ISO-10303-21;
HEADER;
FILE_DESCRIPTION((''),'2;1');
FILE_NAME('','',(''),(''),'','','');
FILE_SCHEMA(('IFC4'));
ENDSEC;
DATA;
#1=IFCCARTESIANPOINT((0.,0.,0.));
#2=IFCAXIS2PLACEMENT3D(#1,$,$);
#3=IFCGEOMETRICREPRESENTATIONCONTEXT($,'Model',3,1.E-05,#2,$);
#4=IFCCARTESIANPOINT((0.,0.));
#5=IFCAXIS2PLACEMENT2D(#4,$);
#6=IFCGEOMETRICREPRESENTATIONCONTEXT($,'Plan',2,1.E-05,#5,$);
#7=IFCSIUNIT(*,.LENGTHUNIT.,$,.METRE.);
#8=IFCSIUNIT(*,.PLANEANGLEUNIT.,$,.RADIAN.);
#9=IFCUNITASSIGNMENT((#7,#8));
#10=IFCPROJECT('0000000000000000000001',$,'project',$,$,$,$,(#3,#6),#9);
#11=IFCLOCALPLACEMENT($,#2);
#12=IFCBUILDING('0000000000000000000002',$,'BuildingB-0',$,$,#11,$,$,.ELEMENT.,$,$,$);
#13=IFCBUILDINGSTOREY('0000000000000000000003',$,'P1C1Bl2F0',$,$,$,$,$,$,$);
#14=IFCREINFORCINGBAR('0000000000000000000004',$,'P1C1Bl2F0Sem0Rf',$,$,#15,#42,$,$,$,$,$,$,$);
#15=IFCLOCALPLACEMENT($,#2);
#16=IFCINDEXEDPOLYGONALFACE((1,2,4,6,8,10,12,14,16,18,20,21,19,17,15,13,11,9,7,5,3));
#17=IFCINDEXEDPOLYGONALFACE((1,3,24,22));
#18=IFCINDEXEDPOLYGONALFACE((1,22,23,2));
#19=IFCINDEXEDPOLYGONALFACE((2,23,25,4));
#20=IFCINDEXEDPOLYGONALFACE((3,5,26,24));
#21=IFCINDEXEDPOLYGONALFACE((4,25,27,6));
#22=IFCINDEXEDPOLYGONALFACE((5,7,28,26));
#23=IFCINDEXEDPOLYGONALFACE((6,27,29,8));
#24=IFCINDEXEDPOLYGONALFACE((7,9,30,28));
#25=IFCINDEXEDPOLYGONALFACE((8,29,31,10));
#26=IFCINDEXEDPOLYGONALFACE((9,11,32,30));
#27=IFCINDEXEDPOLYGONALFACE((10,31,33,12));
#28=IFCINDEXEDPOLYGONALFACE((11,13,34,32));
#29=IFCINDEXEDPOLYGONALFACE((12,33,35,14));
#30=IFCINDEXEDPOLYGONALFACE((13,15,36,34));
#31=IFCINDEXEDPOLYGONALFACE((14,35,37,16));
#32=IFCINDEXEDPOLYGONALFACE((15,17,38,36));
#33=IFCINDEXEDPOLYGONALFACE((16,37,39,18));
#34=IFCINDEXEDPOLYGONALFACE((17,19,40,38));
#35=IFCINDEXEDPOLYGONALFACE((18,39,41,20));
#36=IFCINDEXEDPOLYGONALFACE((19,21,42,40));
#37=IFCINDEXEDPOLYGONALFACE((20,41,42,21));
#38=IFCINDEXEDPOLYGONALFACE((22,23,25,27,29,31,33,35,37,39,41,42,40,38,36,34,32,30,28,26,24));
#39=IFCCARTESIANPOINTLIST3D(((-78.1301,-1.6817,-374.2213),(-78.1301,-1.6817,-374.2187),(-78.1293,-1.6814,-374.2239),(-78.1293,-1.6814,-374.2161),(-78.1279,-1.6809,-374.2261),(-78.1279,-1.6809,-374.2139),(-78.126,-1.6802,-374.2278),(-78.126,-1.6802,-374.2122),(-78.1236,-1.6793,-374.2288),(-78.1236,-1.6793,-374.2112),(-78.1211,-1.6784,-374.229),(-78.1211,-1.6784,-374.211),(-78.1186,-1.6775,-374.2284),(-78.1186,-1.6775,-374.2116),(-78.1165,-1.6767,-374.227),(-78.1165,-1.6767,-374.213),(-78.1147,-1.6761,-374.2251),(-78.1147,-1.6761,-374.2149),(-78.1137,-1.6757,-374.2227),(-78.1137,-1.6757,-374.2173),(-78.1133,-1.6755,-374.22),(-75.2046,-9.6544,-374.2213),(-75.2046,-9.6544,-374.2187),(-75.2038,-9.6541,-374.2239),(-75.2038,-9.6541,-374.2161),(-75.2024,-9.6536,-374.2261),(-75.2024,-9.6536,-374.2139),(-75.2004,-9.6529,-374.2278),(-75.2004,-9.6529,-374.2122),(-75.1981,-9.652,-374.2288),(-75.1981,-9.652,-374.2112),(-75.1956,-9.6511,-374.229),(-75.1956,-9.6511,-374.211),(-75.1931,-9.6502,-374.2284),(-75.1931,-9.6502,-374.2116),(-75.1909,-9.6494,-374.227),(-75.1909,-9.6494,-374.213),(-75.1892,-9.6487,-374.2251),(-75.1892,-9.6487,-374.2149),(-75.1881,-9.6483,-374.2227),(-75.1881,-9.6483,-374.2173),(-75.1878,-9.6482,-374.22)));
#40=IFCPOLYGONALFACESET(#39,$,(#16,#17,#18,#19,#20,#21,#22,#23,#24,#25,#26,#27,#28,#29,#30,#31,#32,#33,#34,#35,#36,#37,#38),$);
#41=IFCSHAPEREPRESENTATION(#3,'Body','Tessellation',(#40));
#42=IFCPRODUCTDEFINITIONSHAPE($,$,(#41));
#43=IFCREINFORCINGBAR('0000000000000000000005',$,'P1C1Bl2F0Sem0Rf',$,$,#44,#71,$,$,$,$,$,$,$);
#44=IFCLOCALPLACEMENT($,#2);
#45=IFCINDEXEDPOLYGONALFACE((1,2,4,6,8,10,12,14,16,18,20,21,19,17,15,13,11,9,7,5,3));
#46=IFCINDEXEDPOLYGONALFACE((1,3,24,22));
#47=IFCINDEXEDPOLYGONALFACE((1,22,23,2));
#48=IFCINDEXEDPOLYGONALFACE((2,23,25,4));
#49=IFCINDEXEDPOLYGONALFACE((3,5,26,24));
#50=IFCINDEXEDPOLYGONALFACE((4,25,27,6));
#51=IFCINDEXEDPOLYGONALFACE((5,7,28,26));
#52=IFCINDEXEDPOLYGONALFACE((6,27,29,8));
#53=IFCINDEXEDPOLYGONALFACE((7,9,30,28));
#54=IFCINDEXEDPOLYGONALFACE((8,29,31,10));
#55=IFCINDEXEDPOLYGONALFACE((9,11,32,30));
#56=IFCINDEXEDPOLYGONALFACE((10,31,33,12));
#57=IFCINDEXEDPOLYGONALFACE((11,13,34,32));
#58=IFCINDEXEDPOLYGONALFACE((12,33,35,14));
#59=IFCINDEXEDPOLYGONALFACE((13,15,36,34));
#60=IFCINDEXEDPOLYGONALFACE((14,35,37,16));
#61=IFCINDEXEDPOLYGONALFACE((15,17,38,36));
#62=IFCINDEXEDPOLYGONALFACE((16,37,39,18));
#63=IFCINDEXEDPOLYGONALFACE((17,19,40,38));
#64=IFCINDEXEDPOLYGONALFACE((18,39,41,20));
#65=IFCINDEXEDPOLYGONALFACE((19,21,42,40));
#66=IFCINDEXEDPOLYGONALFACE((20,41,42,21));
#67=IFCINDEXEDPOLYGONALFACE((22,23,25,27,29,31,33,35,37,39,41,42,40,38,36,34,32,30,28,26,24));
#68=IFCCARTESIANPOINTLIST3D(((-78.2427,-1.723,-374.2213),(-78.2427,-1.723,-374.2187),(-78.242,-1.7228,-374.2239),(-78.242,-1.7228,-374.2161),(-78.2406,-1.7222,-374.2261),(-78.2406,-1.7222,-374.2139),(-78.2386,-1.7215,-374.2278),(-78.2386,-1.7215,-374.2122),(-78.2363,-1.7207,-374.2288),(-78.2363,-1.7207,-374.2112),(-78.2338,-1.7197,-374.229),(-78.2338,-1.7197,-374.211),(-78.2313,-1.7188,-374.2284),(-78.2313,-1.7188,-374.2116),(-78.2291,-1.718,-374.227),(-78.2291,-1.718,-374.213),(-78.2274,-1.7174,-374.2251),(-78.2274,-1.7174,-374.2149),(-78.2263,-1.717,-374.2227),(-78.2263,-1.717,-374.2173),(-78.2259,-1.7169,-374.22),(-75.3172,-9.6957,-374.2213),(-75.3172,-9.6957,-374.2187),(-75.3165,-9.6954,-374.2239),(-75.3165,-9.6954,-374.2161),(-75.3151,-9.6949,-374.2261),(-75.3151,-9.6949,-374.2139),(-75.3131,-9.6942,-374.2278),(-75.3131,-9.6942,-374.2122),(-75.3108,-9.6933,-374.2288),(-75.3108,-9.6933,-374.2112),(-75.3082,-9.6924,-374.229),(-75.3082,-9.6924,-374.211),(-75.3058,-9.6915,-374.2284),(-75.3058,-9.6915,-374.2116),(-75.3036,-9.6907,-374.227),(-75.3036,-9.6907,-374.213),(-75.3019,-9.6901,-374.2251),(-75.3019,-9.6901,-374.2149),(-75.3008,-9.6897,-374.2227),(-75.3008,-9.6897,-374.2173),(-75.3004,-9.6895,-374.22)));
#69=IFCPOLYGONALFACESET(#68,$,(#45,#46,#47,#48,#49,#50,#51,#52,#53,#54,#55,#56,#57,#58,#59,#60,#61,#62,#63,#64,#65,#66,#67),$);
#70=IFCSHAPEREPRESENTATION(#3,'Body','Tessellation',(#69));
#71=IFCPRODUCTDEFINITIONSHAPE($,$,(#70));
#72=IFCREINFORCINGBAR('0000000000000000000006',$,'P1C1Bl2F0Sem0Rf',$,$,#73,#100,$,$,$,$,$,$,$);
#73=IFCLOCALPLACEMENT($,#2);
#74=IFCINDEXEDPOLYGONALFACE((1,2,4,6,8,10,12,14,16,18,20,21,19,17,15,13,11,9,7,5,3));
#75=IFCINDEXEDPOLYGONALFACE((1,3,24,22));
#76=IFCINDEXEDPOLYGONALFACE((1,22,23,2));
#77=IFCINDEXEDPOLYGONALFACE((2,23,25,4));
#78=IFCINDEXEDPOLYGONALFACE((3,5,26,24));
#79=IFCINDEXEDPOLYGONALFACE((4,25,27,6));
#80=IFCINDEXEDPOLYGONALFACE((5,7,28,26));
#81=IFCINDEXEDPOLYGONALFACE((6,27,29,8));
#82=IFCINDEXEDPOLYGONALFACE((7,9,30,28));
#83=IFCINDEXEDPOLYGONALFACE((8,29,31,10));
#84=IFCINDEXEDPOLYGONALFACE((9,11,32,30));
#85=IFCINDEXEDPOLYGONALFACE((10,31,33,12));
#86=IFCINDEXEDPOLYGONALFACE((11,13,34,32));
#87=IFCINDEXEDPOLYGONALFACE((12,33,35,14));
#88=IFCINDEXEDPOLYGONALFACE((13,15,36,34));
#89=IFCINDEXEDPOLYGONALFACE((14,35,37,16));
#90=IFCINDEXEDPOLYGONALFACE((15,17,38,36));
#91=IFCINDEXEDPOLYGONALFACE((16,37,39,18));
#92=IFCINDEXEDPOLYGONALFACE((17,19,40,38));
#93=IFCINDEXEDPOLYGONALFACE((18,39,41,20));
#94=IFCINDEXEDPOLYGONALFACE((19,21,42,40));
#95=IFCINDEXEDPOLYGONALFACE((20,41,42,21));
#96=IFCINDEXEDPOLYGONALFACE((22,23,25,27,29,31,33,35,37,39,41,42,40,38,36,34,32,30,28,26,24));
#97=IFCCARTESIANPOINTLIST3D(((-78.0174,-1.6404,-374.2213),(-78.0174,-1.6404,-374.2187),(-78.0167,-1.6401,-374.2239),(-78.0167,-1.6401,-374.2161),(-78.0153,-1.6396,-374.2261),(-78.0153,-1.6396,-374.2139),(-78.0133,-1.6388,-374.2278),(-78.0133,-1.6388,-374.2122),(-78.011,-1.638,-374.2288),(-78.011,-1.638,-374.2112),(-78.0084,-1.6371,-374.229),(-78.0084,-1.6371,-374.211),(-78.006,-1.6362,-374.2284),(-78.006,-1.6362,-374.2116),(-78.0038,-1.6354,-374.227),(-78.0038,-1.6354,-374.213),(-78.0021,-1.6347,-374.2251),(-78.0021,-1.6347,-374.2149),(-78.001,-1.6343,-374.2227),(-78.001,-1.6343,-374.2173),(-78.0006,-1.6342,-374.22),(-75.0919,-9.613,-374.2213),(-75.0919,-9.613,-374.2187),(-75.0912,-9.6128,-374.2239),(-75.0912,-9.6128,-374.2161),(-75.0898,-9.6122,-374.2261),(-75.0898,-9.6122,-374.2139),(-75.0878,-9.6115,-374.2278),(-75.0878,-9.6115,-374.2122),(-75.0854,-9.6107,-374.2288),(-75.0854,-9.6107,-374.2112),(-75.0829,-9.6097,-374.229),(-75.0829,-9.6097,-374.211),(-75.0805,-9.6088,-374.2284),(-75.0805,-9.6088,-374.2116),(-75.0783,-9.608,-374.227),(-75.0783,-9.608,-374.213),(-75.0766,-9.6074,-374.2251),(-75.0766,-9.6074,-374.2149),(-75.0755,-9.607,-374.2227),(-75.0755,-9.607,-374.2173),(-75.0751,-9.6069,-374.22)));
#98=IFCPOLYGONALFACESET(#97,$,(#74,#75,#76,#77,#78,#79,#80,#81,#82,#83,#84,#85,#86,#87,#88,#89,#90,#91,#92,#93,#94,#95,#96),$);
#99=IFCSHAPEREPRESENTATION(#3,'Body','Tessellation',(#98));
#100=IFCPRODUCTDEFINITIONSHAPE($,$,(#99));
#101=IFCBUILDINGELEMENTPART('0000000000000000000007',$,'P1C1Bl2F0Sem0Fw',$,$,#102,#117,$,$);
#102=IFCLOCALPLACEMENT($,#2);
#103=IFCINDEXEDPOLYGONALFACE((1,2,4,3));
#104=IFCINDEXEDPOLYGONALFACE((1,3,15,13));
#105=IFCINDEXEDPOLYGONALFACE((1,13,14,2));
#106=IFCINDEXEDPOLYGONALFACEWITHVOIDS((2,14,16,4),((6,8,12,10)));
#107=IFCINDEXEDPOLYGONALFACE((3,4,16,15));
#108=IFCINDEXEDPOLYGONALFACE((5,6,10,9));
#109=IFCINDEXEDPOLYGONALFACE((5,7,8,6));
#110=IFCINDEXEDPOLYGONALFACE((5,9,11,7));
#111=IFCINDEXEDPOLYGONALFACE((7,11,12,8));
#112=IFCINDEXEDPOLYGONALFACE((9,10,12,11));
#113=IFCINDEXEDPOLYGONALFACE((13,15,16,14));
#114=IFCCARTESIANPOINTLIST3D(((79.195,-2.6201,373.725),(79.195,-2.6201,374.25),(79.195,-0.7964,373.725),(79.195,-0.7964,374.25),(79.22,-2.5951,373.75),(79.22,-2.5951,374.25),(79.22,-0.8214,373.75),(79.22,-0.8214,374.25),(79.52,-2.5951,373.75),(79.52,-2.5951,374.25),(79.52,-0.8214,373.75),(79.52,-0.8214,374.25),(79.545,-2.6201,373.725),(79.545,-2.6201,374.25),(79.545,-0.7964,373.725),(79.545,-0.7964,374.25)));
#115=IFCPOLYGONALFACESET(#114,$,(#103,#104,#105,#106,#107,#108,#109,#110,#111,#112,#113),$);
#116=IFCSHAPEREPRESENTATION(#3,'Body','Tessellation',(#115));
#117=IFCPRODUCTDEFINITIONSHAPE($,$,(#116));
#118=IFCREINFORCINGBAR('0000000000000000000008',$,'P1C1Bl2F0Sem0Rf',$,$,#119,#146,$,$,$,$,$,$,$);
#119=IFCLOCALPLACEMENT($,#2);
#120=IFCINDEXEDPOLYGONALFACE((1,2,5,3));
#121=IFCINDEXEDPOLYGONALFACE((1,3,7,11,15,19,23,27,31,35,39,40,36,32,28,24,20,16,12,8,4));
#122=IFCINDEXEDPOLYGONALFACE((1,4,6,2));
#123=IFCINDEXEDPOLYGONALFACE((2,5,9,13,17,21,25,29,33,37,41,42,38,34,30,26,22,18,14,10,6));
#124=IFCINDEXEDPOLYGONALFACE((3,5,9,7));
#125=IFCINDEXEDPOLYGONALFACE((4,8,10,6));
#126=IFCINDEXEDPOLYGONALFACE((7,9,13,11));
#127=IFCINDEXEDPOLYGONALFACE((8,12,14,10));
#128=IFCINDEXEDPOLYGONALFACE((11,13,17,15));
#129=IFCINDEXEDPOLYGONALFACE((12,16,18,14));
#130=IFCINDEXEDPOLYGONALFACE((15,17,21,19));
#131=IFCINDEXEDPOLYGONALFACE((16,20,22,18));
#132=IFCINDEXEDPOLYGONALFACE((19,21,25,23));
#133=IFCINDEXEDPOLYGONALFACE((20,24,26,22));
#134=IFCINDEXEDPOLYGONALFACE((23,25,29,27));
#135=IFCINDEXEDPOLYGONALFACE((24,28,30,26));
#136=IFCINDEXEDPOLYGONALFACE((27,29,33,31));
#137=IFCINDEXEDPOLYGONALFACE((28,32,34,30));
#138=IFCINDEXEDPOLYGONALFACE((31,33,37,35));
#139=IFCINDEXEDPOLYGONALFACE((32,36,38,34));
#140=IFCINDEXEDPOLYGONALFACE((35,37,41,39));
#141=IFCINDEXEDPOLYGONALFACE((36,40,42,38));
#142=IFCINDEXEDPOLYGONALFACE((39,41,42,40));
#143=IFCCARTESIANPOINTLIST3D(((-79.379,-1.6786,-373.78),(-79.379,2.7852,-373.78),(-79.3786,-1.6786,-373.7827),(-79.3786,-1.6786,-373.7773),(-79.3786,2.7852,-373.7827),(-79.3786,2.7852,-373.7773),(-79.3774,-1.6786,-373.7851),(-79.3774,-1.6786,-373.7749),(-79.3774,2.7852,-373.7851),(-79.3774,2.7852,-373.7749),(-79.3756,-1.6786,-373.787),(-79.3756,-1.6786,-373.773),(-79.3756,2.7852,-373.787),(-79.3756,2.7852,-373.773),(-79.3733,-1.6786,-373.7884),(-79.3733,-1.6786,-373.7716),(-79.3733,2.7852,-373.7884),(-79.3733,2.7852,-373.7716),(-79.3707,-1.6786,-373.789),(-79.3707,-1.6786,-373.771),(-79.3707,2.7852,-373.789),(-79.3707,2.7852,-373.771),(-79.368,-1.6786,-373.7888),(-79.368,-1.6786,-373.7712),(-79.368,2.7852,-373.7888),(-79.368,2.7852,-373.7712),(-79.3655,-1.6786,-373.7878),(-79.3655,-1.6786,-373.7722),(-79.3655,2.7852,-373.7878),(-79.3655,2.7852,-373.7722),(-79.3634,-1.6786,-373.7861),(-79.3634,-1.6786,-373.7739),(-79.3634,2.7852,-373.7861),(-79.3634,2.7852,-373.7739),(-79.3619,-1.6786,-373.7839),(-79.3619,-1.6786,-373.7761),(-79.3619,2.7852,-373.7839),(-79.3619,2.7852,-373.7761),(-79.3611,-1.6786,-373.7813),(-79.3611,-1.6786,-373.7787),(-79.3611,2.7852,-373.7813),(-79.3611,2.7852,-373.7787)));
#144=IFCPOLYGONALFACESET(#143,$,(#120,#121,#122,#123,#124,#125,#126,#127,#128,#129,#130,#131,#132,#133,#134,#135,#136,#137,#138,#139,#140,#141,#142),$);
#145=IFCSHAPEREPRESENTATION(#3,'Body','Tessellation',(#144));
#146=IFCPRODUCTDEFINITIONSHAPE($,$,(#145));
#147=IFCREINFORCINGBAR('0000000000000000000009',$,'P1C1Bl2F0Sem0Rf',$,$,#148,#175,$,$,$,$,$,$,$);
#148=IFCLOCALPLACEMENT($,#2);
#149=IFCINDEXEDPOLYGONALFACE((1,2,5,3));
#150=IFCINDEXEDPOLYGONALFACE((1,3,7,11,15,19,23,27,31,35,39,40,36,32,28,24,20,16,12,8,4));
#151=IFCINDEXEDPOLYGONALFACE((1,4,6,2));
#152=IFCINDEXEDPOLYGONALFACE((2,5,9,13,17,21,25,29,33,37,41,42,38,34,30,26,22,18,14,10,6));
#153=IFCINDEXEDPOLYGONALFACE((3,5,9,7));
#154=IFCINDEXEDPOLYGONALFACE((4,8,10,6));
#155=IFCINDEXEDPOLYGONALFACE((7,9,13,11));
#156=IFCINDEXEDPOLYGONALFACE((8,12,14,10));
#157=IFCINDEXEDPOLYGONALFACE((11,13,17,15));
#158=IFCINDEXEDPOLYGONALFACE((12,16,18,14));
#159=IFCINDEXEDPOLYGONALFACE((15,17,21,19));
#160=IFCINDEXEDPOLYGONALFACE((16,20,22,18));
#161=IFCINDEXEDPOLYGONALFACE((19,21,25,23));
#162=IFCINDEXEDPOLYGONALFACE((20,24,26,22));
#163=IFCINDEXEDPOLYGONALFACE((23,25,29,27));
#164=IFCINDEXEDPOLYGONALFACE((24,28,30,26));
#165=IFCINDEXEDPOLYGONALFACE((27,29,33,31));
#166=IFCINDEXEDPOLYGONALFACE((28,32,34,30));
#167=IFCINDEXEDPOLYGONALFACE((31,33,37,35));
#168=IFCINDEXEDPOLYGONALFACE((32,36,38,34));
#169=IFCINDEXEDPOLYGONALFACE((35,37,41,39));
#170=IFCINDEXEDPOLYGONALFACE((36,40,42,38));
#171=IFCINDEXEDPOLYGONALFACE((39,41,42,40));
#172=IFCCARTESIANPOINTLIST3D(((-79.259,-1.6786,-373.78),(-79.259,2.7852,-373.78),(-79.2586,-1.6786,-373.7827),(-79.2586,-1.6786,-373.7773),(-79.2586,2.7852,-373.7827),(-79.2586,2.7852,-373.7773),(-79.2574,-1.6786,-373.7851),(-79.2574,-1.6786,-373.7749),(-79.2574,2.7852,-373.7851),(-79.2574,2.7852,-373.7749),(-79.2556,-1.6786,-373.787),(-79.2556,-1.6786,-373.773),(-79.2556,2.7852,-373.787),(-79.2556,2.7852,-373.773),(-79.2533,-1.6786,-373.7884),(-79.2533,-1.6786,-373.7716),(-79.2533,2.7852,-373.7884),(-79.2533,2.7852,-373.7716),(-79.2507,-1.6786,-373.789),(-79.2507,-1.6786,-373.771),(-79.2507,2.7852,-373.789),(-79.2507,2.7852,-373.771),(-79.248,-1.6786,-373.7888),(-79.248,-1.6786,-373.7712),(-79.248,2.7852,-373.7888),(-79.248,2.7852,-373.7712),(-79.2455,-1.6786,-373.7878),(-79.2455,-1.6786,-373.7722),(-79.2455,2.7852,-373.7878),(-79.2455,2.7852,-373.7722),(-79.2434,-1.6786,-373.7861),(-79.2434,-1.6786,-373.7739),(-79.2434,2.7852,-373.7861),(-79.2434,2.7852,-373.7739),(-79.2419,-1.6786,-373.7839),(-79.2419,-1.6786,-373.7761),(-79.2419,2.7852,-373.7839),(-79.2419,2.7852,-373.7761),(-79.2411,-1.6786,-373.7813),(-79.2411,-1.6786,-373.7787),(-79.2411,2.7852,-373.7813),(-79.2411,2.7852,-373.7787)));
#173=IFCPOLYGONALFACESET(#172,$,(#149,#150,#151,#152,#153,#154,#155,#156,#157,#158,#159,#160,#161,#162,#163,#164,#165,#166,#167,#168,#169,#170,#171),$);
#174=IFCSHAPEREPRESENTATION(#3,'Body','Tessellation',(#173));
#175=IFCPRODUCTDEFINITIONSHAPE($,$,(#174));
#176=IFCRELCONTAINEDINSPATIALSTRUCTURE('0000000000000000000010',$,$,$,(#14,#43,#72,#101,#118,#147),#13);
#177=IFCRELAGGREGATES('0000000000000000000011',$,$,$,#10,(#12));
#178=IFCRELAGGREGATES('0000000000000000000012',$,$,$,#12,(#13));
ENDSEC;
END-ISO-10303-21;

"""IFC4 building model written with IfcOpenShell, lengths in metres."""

from ifc_helpers import new_model, entity, si_unit, origin, origin_2d, place, context, project, spatial, polyline, outline, extrude, element, save


model = new_model("IFC4")

# Units and contexts
model_context = context("Model", 3, precision=1e-05, world=origin())
plan_context = context("Plan", 2, precision=1e-05, world=origin_2d())
ifc_project = project(units=[si_unit("LENGTHUNIT", "METRE"), si_unit("PLANEANGLEUNIT", "RADIAN")], contexts=[model_context, plan_context])

# Building, storey
building_placement = place(None, origin())
building = spatial("IfcBuilding", under=ifc_project, at=building_placement, Name="BuildingB-0", CompositionType="ELEMENT")
storey = spatial("IfcBuildingStorey", under=building, Name="P1C1Bl2F0")

# Reinforcing bars
element("IfcReinforcingBar", 1, inside=storey, Name="P1C1Bl2F0Sem0Rf", context=model_context, shape_type="SweptSolid", body=[
    entity("IfcSurfaceCurveSweptAreaSolid", entity("IfcCircleProfileDef", "AREA", None, None, 0.009), None, entity("IfcPolyline", [entity("IfcCartesianPoint", [78.1217, 1.6786, 374.22]), entity("IfcCartesianPoint", [75.1962, 9.6513, 374.22])]), None, None, entity("IfcPlane", entity("IfcAxis2Placement3D", entity("IfcCartesianPoint", [78.1217, 1.6786, 374.22]), entity("IfcDirection", [0.0, 0.0, 1.0]), entity("IfcDirection", [1.0, 0.0, 0.0])))),
])
element("IfcReinforcingBar", 2, inside=storey, Name="P1C1Bl2F0Sem0Rf", context=model_context, shape_type="SweptSolid", body=[
    entity("IfcSurfaceCurveSweptAreaSolid", entity("IfcCircleProfileDef", "AREA", None, None, 0.009), None, entity("IfcPolyline", [entity("IfcCartesianPoint", [78.2344, 1.72, 374.22]), entity("IfcCartesianPoint", [75.3089, 9.6926, 374.22])]), None, None, entity("IfcPlane", entity("IfcAxis2Placement3D", entity("IfcCartesianPoint", [78.2344, 1.72, 374.22]), entity("IfcDirection", [0.0, 0.0, 1.0]), entity("IfcDirection", [1.0, 0.0, 0.0])))),
])
element("IfcReinforcingBar", 3, inside=storey, Name="P1C1Bl2F0Sem0Rf", context=model_context, shape_type="SweptSolid", body=[
    entity("IfcSurfaceCurveSweptAreaSolid", entity("IfcCircleProfileDef", "AREA", None, None, 0.009), None, entity("IfcPolyline", [entity("IfcCartesianPoint", [78.0091, 1.6373, 374.22]), entity("IfcCartesianPoint", [75.0836, 9.61, 374.22])]), None, None, entity("IfcPlane", entity("IfcAxis2Placement3D", entity("IfcCartesianPoint", [78.0091, 1.6373, 374.22]), entity("IfcDirection", [0.0, 0.0, 1.0]), entity("IfcDirection", [1.0, 0.0, 0.0])))),
])

# Building element part, opening
building_element_part_1 = element("IfcBuildingElementPart", 4, inside=storey, Name="P1C1Bl2F0Sem0Fw", context=model_context, shape_type="SweptSolid", body=[
    extrude(outline(polyline([(79.545, -2.6201, 373.725), (79.195, -2.6201, 373.725), (79.195, -0.7964, 373.725), (79.545, -0.7964, 373.725), (79.545, -2.6201, 373.725)])), None, (0.0, 0.0, 1.0), 0.525),
])
element("IfcOpeningElement", 5, inside=storey, cuts=building_element_part_1, context=model_context, shape_type="SweptSolid", body=[
    extrude(outline(polyline([(79.52, -2.5951, 373.75), (79.22, -2.5951, 373.75), (79.22, -0.8214, 373.75), (79.52, -0.8214, 373.75), (79.52, -2.5951, 373.75)])), None, (0.0, 0.0, 1.0), 0.5),
])

# Reinforcing bars
element("IfcReinforcingBar", 6, inside=storey, Name="P1C1Bl2F0Sem0Rf", context=model_context, shape_type="SweptSolid", body=[
    entity("IfcSurfaceCurveSweptAreaSolid", entity("IfcCircleProfileDef", "AREA", None, None, 0.009), None, entity("IfcPolyline", [entity("IfcCartesianPoint", [79.37, 1.6786, 373.78]), entity("IfcCartesianPoint", [79.37, -2.7852, 373.78])]), None, None, entity("IfcPlane", entity("IfcAxis2Placement3D", entity("IfcCartesianPoint", [79.37, 1.6786, 373.78]), entity("IfcDirection", [0.0, 0.0, 1.0]), entity("IfcDirection", [1.0, 0.0, 0.0])))),
])
element("IfcReinforcingBar", 7, inside=storey, Name="P1C1Bl2F0Sem0Rf", context=model_context, shape_type="SweptSolid", body=[
    entity("IfcSurfaceCurveSweptAreaSolid", entity("IfcCircleProfileDef", "AREA", None, None, 0.009), None, entity("IfcPolyline", [entity("IfcCartesianPoint", [79.25, 1.6786, 373.78]), entity("IfcCartesianPoint", [79.25, -2.7852, 373.78])]), None, None, entity("IfcPlane", entity("IfcAxis2Placement3D", entity("IfcCartesianPoint", [79.25, 1.6786, 373.78]), entity("IfcDirection", [0.0, 0.0, 1.0]), entity("IfcDirection", [1.0, 0.0, 0.0])))),
])

save(model, "model.ifc")
